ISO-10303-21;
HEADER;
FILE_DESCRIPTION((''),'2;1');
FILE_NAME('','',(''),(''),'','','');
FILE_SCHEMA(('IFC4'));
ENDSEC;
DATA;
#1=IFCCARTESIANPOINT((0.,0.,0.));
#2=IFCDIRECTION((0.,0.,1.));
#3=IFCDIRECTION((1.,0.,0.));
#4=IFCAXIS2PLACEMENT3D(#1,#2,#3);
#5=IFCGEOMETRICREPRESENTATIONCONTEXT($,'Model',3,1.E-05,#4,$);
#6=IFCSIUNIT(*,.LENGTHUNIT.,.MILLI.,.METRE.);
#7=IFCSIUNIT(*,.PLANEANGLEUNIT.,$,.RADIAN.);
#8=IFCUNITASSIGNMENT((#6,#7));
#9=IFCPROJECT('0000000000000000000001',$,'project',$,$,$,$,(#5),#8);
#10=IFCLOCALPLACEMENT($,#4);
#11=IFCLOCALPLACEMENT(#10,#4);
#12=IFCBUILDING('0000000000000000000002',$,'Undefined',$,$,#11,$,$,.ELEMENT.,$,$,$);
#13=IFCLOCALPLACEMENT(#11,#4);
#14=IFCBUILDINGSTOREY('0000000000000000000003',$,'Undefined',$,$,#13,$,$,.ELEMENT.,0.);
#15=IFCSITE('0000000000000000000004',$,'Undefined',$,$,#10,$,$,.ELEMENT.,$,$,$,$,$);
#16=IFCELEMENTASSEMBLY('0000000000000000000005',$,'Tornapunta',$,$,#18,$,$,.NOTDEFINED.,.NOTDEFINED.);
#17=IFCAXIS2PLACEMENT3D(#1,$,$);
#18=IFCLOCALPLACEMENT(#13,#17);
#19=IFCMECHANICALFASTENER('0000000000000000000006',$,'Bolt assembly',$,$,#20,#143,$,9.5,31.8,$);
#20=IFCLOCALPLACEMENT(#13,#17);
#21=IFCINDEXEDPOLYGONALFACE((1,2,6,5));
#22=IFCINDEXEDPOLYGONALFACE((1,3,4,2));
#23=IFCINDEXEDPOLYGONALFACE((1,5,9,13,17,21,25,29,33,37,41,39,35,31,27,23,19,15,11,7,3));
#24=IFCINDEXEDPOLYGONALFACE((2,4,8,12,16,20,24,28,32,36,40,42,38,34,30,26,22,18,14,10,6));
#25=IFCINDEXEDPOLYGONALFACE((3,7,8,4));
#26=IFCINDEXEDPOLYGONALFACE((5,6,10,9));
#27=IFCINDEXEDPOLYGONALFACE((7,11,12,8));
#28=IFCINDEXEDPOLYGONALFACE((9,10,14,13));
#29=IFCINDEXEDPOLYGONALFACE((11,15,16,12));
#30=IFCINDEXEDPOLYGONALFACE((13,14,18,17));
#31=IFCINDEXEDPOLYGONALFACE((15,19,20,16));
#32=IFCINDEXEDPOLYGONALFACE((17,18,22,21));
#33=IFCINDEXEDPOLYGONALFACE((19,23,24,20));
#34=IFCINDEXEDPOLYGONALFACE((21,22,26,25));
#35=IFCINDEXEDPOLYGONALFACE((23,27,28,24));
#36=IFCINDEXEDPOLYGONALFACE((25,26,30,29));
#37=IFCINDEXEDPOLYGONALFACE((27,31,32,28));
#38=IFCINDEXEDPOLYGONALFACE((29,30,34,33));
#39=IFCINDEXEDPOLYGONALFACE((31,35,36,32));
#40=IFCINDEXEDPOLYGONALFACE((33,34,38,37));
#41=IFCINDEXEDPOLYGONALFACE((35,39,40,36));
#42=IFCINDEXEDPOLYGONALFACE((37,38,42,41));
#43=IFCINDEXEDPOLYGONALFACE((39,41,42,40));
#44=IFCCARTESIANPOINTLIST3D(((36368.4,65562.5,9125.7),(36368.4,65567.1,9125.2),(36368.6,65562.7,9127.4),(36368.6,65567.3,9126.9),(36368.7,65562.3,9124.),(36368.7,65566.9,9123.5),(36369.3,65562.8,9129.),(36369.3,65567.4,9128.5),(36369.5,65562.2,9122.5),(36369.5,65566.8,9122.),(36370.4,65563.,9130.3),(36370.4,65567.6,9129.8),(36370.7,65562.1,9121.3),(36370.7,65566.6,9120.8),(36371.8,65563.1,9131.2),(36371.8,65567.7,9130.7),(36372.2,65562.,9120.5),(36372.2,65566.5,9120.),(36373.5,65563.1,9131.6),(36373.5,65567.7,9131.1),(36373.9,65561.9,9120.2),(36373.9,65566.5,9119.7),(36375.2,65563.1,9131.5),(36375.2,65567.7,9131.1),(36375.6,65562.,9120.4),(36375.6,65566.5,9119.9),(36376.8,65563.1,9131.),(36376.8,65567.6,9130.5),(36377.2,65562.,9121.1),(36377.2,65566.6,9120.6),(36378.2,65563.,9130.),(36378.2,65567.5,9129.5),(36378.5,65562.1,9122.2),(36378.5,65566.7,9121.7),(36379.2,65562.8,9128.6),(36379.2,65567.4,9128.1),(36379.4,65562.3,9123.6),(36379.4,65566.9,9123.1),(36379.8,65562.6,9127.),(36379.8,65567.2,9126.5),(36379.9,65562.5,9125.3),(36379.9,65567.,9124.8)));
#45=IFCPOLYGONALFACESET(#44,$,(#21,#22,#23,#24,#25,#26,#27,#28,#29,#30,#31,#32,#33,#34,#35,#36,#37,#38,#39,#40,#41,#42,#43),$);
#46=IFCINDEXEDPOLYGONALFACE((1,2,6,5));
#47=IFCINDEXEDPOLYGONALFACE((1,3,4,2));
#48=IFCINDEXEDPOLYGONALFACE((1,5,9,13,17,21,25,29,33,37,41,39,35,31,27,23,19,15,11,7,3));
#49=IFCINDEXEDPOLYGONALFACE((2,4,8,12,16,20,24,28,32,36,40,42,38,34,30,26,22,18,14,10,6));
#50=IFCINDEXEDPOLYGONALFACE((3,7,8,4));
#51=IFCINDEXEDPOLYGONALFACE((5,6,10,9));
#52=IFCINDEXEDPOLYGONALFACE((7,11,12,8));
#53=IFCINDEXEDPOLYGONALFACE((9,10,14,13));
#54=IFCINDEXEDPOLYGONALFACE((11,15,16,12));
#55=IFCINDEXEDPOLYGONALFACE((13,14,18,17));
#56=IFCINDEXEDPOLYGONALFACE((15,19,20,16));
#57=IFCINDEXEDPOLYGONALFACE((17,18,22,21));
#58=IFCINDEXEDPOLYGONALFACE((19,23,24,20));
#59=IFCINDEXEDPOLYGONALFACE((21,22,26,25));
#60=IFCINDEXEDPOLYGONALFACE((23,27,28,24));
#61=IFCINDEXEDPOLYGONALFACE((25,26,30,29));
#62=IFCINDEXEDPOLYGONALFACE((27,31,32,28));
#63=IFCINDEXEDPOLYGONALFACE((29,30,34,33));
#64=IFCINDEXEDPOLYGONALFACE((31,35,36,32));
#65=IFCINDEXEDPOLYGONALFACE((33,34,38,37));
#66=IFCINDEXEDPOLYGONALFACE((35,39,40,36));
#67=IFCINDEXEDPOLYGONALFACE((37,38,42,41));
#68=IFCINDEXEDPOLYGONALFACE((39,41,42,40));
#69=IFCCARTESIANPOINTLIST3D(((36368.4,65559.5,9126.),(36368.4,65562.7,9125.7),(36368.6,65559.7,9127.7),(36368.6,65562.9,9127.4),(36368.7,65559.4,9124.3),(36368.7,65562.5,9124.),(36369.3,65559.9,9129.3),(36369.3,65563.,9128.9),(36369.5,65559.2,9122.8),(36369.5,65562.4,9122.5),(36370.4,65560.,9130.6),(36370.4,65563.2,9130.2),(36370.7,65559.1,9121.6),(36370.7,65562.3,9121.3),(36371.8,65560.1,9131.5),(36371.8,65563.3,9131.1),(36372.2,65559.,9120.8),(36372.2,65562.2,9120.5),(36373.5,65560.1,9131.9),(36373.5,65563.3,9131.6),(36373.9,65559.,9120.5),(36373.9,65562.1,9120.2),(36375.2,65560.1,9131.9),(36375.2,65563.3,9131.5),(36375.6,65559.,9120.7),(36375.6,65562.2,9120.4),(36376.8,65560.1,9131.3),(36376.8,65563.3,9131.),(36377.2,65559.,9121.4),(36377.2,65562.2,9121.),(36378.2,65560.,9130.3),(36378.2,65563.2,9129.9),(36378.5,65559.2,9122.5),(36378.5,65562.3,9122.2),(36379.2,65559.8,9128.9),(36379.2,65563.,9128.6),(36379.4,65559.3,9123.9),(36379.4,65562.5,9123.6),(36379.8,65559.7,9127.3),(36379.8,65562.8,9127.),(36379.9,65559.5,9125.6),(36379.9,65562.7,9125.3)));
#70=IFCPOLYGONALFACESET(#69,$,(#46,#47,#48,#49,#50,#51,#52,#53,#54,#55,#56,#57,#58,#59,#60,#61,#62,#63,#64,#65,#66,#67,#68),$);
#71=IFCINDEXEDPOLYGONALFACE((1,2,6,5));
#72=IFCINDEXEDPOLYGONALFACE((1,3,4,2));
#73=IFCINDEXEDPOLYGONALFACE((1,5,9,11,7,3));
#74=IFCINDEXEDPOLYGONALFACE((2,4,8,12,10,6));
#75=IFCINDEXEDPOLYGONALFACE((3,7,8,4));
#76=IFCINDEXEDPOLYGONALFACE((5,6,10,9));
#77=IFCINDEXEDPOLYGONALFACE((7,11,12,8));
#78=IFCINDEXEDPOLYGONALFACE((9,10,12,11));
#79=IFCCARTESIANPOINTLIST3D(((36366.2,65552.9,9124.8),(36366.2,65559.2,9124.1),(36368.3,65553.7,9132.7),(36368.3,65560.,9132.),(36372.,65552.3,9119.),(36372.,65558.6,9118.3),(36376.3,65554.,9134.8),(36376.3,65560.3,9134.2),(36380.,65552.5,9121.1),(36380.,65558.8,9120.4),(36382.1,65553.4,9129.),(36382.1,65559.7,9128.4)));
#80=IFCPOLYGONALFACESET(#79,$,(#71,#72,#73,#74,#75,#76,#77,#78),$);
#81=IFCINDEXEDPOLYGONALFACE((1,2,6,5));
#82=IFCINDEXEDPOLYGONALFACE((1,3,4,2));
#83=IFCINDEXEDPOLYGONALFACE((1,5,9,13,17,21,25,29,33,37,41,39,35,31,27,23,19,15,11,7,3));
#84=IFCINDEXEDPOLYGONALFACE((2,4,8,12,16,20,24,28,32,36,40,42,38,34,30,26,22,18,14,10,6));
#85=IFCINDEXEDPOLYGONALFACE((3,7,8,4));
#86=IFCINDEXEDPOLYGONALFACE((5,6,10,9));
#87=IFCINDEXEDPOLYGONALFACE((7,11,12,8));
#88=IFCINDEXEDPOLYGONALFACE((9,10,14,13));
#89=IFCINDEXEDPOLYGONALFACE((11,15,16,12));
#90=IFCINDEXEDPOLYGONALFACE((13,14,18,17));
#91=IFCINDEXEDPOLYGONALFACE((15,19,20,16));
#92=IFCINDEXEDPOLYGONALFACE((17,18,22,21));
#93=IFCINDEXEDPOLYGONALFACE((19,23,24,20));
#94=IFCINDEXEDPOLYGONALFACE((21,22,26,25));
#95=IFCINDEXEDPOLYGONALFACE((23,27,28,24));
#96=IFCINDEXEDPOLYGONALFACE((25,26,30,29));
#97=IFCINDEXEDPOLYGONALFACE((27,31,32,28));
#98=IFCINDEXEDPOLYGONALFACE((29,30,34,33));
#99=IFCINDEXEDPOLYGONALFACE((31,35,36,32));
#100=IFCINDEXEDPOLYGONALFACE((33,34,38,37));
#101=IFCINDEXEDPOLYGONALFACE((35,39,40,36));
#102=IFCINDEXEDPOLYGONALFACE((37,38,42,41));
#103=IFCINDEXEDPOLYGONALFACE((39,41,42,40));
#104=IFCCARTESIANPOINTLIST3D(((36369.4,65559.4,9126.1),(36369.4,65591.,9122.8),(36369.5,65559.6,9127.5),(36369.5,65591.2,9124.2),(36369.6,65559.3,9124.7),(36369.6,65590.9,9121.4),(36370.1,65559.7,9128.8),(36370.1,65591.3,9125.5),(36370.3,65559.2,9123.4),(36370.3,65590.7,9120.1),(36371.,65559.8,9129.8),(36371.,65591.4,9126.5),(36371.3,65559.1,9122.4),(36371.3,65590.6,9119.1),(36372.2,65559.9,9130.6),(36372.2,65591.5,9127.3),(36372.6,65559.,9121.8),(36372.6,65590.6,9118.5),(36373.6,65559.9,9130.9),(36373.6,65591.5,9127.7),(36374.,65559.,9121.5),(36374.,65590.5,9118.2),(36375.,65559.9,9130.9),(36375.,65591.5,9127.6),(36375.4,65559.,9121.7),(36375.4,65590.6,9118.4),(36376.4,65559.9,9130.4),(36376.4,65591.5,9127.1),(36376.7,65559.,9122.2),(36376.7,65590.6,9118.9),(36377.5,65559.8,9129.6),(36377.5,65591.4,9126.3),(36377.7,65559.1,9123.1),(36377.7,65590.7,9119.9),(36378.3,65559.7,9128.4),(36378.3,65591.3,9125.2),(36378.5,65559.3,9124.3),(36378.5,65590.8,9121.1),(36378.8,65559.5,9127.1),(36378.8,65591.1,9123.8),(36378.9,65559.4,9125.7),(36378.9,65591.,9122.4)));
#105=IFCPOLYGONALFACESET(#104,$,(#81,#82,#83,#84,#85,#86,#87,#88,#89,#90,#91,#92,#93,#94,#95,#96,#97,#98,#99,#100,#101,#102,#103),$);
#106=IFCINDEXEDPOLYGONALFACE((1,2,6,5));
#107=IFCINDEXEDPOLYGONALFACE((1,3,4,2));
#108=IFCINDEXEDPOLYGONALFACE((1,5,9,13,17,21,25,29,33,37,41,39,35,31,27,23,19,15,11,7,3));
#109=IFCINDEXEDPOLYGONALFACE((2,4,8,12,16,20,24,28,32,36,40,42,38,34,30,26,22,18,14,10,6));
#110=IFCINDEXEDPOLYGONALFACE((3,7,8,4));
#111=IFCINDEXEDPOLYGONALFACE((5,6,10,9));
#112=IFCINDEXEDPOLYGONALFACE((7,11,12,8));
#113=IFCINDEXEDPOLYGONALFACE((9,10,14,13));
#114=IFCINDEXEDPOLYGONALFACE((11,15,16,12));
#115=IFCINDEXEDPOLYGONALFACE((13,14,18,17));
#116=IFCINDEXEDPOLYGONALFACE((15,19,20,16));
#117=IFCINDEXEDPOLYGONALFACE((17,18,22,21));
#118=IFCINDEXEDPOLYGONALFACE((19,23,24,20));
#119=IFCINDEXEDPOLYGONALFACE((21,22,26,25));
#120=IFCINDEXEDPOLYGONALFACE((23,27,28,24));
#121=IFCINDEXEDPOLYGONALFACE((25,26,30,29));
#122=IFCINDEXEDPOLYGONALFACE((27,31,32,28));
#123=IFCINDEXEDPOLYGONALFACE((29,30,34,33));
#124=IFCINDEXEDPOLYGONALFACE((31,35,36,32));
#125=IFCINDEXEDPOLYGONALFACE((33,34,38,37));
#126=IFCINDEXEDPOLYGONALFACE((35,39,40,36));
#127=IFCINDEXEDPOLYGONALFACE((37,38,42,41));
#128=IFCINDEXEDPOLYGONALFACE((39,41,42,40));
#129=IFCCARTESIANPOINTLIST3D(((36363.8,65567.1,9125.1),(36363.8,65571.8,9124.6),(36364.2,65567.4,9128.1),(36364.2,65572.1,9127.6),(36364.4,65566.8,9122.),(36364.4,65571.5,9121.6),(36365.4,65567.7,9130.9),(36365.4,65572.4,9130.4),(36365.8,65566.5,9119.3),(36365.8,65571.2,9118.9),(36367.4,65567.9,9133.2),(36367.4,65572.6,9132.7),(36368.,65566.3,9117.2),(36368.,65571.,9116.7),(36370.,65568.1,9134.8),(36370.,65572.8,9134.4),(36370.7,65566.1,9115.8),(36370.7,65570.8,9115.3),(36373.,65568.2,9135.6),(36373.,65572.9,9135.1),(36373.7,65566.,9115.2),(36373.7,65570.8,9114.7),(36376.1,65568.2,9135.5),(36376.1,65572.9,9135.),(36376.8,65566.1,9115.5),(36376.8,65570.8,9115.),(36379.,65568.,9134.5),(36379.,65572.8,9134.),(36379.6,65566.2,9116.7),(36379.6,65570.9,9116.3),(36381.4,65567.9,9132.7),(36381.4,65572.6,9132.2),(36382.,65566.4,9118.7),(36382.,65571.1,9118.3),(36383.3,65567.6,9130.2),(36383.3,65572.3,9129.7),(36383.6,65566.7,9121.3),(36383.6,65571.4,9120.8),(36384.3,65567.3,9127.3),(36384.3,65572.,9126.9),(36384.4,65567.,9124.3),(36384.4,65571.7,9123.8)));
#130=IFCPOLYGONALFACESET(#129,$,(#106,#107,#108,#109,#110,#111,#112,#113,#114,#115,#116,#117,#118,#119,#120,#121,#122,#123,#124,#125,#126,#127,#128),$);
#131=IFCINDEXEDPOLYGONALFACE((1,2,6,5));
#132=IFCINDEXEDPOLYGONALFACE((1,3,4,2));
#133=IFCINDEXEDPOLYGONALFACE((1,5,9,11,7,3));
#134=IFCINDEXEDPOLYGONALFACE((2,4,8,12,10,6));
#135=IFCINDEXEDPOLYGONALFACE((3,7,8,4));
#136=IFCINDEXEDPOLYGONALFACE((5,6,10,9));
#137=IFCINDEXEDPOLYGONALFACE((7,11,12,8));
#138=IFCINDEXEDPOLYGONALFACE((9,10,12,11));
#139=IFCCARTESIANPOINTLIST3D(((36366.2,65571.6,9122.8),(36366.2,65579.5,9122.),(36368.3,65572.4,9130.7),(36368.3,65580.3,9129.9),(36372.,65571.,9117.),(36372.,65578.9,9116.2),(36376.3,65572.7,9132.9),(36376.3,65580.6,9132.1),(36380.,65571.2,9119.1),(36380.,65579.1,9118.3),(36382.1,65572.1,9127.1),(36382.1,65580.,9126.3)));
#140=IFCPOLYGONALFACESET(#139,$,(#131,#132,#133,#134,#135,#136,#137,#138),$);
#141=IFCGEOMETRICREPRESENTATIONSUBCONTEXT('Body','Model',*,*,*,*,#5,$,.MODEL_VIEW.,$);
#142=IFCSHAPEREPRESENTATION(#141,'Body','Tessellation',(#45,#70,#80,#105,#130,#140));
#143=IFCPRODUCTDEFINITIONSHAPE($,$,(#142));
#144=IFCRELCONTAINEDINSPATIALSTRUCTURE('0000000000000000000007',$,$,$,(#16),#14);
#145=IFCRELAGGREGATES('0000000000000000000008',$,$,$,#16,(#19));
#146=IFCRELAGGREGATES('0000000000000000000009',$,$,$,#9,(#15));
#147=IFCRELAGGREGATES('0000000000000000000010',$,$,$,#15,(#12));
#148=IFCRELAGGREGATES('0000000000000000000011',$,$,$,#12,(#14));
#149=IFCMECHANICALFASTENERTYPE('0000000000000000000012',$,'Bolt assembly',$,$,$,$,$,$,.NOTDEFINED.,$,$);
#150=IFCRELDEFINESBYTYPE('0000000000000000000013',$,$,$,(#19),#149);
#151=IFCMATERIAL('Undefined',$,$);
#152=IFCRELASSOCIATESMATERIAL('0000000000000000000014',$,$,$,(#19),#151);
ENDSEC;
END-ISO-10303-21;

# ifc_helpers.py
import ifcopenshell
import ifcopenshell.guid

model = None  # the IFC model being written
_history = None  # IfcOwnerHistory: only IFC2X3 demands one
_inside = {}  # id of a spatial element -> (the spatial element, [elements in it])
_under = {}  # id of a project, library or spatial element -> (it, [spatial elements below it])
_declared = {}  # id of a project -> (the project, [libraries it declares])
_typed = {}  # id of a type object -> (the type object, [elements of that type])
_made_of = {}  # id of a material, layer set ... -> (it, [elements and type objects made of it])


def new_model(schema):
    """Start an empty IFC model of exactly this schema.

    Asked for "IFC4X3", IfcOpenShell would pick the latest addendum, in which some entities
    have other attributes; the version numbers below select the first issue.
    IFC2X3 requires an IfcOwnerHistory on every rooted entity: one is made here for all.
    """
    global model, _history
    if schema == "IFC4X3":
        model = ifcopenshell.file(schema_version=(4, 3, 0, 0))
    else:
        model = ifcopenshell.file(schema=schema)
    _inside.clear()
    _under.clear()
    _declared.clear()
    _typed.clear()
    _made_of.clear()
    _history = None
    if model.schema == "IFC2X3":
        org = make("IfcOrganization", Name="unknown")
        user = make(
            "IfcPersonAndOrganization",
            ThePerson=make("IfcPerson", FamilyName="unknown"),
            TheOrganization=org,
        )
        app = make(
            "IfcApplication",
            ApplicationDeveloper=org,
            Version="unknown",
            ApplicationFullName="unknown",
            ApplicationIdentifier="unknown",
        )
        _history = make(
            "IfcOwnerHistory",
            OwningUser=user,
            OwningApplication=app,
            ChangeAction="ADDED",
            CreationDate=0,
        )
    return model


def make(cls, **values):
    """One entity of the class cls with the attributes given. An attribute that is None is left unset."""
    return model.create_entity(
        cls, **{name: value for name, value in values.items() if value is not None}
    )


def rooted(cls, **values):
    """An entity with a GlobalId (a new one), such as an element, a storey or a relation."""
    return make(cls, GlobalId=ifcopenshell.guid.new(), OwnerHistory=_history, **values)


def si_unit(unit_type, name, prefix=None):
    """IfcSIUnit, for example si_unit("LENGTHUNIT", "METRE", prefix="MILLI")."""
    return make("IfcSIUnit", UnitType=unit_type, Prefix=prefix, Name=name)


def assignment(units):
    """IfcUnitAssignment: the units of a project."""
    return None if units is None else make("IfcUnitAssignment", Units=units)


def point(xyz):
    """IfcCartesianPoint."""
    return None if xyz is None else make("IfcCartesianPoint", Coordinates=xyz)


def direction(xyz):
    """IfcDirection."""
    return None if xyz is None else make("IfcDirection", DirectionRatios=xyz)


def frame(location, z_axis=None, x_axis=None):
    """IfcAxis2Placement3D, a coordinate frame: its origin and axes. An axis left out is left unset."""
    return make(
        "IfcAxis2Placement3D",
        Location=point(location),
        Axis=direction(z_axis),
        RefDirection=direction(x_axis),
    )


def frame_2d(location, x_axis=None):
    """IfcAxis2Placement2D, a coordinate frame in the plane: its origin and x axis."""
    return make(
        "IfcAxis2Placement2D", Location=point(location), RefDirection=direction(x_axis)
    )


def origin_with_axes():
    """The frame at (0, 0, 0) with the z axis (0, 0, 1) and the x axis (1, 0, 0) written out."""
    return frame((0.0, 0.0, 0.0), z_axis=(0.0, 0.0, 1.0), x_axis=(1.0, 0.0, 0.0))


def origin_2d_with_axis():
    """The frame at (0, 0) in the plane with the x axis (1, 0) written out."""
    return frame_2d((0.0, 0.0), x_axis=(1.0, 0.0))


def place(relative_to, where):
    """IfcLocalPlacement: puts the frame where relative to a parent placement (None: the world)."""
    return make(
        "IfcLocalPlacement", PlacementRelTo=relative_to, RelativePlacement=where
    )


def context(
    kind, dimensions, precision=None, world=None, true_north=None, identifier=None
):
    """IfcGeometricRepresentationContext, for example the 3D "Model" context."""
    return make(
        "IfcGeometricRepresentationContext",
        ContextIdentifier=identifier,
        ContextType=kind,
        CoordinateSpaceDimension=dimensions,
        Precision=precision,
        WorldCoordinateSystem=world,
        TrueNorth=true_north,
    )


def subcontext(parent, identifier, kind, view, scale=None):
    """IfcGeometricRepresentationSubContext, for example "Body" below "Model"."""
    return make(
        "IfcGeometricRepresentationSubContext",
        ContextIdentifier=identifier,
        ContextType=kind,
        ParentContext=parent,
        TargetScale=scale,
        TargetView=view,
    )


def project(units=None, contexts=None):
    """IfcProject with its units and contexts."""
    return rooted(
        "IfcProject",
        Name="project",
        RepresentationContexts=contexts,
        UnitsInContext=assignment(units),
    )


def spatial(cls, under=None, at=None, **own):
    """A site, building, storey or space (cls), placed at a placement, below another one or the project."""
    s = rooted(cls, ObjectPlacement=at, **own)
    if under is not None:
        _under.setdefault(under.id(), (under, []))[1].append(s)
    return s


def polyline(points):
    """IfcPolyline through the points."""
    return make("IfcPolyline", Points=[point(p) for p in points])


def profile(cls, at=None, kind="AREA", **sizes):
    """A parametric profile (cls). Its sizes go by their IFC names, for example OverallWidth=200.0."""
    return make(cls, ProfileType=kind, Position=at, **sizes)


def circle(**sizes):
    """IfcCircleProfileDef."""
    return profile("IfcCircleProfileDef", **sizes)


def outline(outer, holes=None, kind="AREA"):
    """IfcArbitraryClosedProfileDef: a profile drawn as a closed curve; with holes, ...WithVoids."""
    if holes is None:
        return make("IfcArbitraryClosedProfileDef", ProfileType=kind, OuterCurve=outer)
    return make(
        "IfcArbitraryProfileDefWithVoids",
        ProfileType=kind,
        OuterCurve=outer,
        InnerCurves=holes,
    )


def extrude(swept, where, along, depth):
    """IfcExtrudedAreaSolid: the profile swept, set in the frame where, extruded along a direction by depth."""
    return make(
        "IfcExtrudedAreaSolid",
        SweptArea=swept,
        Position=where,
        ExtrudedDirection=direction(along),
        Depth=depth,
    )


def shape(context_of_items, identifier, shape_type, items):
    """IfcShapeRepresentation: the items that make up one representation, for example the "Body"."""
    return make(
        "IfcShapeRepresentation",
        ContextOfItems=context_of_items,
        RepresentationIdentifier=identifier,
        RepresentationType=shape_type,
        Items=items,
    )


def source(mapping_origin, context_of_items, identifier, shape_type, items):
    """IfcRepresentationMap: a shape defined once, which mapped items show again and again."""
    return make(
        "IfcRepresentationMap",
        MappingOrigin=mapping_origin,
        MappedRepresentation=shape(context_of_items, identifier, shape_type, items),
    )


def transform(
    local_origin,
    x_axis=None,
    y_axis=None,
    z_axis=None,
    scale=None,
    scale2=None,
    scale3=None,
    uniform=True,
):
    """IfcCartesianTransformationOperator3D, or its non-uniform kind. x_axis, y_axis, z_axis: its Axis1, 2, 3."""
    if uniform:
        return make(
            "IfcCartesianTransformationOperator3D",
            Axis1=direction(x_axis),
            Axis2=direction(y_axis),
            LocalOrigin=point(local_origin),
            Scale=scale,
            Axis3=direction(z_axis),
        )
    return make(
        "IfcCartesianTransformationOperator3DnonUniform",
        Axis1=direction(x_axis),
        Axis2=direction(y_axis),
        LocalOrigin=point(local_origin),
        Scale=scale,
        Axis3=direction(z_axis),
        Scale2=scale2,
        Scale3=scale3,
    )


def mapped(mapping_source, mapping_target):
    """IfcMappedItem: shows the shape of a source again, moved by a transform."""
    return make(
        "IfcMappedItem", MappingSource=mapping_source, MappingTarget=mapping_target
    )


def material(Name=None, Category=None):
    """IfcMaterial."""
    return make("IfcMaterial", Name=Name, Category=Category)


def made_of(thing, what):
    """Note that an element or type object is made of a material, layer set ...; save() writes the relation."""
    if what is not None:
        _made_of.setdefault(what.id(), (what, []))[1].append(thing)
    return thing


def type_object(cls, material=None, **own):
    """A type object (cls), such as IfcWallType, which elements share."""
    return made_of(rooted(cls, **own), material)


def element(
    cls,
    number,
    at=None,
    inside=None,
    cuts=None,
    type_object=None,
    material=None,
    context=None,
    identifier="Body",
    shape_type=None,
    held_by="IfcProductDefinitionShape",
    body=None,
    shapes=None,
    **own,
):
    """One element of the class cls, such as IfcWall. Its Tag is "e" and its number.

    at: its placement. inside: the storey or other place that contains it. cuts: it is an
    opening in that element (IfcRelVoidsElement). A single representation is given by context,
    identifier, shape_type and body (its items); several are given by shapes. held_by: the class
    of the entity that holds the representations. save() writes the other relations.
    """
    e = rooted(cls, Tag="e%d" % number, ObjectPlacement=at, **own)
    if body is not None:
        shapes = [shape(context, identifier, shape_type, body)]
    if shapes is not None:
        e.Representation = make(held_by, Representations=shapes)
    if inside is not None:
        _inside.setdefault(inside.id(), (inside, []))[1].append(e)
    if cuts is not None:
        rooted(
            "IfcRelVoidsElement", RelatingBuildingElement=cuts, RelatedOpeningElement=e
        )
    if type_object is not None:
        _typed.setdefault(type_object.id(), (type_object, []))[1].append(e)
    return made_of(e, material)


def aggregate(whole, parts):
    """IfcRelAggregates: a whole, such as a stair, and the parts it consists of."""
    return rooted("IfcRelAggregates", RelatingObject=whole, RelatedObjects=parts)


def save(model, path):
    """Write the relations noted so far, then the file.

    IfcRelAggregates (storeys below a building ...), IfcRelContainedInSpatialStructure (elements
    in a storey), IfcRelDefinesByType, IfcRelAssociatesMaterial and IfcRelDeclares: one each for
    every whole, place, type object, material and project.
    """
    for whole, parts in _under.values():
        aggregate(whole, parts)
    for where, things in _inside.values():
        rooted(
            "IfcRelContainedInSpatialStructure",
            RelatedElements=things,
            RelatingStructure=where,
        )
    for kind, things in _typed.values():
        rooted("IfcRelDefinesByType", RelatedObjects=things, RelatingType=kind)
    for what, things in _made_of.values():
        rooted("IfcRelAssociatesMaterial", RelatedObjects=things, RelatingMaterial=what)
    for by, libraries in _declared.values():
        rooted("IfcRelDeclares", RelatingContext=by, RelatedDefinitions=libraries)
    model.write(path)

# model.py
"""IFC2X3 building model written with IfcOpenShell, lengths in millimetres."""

from ifc_helpers import new_model, si_unit, frame, origin_with_axes, origin_2d_with_axis, place, context, subcontext, project, spatial, polyline, circle, outline, extrude, source, transform, mapped, material, type_object, element, aggregate, save


model = new_model("IFC2X3")

# Units and contexts
model_context = context("Model", 3, precision=1e-05, world=origin_with_axes())
body_context = subcontext(model_context, "Body", "Model", "MODEL_VIEW")
ifc_project = project(units=[si_unit("LENGTHUNIT", "METRE", prefix="MILLI"), si_unit("PLANEANGLEUNIT", "RADIAN")], contexts=[model_context])

# Site, building, storey
site_placement = place(None, origin_with_axes())
site = spatial("IfcSite", under=ifc_project, at=site_placement, Name="Undefined", CompositionType="ELEMENT")
building_placement = place(site_placement, origin_with_axes())
building = spatial("IfcBuilding", under=site, at=building_placement, Name="Undefined", CompositionType="ELEMENT")
storey_placement = place(building_placement, origin_with_axes())
storey = spatial("IfcBuildingStorey", under=building, at=storey_placement, Name="Undefined", CompositionType="ELEMENT", Elevation=0.0)

# Element assembly
assembly_1_placement = place(storey_placement, origin_with_axes())
assembly_1 = element("IfcElementAssembly", 1, at=assembly_1_placement, inside=storey, Name="Tornapunta", AssemblyPlace="NOTDEFINED", PredefinedType="NOTDEFINED")

# Shared definitions
ifc_material_1 = material(Name="Undefined")
mechanical_fastener_type = type_object("IfcMechanicalFastenerType", Name="Bolt assembly")

# Mechanical fastener
shared_shape_1 = source(origin_with_axes(), body_context, "Body", "SweptSolid", [
    extrude(circle(Radius=5.8, at=origin_2d_with_axis()), frame((0.0, -0.1, 0.0), z_axis=(0.0, 1.0, 0.0), x_axis=(1.0, 0.0, 0.0)), (0.0, 0.0, 1.0), 4.6),
    extrude(circle(Radius=5.8, at=origin_2d_with_axis()), frame((0.0, -3.1, 0.0), z_axis=(0.0, 1.0, 0.0), x_axis=(1.0, 0.0, 0.0)), (0.0, 0.0, 1.0), 3.2),
    extrude(outline(polyline([(7.1, -4.1), (7.1, 4.1), (0.0, 8.2), (-7.1, 4.1), (-7.1, -4.1), (0.0, -8.2), (7.1, -4.1)])), frame((0.0, -9.5, 0.0), z_axis=(0.0, 1.0, 0.0), x_axis=(1.0, 0.0, 0.0)), (0.0, 0.0, 1.0), 6.3),
    extrude(circle(Radius=4.8, at=origin_2d_with_axis()), frame((0.0, -3.2, 0.0), z_axis=(0.0, 1.0, 0.0), x_axis=(1.0, 0.0, 0.0)), (0.0, 0.0, 1.0), 31.8),
    extrude(circle(Radius=10.3, at=origin_2d_with_axis()), frame((0.0, 4.5, 0.0), z_axis=(0.0, 1.0, 0.0), x_axis=(1.0, 0.0, 0.0)), (0.0, 0.0, 1.0), 4.8),
    extrude(outline(polyline([(7.1, -4.1), (7.1, 4.1), (0.0, 8.2), (-7.1, 4.1), (-7.1, -4.1), (0.0, -8.2), (7.1, -4.1)])), frame((0.0, 9.3, 0.0), z_axis=(0.0, 1.0, 0.0), x_axis=(1.0, 0.0, 0.0)), (0.0, 0.0, 1.0), 7.9),
])
mechanical_fastener_1_placement = place(assembly_1_placement, frame((36374.1, 65562.6, 9125.9), z_axis=(-0.707107, 0.072947, 0.703334), x_axis=(0.707107, 0.072947, 0.703334)))
mechanical_fastener_1 = element("IfcMechanicalFastener", 2, at=mechanical_fastener_1_placement, type_object=mechanical_fastener_type, material=ifc_material_1, Name="Bolt assembly", NominalDiameter=9.5, NominalLength=31.8, context=body_context, shape_type="MappedRepresentation", body=[
    mapped(shared_shape_1, transform((0.0, 0.0, 0.0))),
])
aggregate(assembly_1, [mechanical_fastener_1])

save(model, "model.ifc")
